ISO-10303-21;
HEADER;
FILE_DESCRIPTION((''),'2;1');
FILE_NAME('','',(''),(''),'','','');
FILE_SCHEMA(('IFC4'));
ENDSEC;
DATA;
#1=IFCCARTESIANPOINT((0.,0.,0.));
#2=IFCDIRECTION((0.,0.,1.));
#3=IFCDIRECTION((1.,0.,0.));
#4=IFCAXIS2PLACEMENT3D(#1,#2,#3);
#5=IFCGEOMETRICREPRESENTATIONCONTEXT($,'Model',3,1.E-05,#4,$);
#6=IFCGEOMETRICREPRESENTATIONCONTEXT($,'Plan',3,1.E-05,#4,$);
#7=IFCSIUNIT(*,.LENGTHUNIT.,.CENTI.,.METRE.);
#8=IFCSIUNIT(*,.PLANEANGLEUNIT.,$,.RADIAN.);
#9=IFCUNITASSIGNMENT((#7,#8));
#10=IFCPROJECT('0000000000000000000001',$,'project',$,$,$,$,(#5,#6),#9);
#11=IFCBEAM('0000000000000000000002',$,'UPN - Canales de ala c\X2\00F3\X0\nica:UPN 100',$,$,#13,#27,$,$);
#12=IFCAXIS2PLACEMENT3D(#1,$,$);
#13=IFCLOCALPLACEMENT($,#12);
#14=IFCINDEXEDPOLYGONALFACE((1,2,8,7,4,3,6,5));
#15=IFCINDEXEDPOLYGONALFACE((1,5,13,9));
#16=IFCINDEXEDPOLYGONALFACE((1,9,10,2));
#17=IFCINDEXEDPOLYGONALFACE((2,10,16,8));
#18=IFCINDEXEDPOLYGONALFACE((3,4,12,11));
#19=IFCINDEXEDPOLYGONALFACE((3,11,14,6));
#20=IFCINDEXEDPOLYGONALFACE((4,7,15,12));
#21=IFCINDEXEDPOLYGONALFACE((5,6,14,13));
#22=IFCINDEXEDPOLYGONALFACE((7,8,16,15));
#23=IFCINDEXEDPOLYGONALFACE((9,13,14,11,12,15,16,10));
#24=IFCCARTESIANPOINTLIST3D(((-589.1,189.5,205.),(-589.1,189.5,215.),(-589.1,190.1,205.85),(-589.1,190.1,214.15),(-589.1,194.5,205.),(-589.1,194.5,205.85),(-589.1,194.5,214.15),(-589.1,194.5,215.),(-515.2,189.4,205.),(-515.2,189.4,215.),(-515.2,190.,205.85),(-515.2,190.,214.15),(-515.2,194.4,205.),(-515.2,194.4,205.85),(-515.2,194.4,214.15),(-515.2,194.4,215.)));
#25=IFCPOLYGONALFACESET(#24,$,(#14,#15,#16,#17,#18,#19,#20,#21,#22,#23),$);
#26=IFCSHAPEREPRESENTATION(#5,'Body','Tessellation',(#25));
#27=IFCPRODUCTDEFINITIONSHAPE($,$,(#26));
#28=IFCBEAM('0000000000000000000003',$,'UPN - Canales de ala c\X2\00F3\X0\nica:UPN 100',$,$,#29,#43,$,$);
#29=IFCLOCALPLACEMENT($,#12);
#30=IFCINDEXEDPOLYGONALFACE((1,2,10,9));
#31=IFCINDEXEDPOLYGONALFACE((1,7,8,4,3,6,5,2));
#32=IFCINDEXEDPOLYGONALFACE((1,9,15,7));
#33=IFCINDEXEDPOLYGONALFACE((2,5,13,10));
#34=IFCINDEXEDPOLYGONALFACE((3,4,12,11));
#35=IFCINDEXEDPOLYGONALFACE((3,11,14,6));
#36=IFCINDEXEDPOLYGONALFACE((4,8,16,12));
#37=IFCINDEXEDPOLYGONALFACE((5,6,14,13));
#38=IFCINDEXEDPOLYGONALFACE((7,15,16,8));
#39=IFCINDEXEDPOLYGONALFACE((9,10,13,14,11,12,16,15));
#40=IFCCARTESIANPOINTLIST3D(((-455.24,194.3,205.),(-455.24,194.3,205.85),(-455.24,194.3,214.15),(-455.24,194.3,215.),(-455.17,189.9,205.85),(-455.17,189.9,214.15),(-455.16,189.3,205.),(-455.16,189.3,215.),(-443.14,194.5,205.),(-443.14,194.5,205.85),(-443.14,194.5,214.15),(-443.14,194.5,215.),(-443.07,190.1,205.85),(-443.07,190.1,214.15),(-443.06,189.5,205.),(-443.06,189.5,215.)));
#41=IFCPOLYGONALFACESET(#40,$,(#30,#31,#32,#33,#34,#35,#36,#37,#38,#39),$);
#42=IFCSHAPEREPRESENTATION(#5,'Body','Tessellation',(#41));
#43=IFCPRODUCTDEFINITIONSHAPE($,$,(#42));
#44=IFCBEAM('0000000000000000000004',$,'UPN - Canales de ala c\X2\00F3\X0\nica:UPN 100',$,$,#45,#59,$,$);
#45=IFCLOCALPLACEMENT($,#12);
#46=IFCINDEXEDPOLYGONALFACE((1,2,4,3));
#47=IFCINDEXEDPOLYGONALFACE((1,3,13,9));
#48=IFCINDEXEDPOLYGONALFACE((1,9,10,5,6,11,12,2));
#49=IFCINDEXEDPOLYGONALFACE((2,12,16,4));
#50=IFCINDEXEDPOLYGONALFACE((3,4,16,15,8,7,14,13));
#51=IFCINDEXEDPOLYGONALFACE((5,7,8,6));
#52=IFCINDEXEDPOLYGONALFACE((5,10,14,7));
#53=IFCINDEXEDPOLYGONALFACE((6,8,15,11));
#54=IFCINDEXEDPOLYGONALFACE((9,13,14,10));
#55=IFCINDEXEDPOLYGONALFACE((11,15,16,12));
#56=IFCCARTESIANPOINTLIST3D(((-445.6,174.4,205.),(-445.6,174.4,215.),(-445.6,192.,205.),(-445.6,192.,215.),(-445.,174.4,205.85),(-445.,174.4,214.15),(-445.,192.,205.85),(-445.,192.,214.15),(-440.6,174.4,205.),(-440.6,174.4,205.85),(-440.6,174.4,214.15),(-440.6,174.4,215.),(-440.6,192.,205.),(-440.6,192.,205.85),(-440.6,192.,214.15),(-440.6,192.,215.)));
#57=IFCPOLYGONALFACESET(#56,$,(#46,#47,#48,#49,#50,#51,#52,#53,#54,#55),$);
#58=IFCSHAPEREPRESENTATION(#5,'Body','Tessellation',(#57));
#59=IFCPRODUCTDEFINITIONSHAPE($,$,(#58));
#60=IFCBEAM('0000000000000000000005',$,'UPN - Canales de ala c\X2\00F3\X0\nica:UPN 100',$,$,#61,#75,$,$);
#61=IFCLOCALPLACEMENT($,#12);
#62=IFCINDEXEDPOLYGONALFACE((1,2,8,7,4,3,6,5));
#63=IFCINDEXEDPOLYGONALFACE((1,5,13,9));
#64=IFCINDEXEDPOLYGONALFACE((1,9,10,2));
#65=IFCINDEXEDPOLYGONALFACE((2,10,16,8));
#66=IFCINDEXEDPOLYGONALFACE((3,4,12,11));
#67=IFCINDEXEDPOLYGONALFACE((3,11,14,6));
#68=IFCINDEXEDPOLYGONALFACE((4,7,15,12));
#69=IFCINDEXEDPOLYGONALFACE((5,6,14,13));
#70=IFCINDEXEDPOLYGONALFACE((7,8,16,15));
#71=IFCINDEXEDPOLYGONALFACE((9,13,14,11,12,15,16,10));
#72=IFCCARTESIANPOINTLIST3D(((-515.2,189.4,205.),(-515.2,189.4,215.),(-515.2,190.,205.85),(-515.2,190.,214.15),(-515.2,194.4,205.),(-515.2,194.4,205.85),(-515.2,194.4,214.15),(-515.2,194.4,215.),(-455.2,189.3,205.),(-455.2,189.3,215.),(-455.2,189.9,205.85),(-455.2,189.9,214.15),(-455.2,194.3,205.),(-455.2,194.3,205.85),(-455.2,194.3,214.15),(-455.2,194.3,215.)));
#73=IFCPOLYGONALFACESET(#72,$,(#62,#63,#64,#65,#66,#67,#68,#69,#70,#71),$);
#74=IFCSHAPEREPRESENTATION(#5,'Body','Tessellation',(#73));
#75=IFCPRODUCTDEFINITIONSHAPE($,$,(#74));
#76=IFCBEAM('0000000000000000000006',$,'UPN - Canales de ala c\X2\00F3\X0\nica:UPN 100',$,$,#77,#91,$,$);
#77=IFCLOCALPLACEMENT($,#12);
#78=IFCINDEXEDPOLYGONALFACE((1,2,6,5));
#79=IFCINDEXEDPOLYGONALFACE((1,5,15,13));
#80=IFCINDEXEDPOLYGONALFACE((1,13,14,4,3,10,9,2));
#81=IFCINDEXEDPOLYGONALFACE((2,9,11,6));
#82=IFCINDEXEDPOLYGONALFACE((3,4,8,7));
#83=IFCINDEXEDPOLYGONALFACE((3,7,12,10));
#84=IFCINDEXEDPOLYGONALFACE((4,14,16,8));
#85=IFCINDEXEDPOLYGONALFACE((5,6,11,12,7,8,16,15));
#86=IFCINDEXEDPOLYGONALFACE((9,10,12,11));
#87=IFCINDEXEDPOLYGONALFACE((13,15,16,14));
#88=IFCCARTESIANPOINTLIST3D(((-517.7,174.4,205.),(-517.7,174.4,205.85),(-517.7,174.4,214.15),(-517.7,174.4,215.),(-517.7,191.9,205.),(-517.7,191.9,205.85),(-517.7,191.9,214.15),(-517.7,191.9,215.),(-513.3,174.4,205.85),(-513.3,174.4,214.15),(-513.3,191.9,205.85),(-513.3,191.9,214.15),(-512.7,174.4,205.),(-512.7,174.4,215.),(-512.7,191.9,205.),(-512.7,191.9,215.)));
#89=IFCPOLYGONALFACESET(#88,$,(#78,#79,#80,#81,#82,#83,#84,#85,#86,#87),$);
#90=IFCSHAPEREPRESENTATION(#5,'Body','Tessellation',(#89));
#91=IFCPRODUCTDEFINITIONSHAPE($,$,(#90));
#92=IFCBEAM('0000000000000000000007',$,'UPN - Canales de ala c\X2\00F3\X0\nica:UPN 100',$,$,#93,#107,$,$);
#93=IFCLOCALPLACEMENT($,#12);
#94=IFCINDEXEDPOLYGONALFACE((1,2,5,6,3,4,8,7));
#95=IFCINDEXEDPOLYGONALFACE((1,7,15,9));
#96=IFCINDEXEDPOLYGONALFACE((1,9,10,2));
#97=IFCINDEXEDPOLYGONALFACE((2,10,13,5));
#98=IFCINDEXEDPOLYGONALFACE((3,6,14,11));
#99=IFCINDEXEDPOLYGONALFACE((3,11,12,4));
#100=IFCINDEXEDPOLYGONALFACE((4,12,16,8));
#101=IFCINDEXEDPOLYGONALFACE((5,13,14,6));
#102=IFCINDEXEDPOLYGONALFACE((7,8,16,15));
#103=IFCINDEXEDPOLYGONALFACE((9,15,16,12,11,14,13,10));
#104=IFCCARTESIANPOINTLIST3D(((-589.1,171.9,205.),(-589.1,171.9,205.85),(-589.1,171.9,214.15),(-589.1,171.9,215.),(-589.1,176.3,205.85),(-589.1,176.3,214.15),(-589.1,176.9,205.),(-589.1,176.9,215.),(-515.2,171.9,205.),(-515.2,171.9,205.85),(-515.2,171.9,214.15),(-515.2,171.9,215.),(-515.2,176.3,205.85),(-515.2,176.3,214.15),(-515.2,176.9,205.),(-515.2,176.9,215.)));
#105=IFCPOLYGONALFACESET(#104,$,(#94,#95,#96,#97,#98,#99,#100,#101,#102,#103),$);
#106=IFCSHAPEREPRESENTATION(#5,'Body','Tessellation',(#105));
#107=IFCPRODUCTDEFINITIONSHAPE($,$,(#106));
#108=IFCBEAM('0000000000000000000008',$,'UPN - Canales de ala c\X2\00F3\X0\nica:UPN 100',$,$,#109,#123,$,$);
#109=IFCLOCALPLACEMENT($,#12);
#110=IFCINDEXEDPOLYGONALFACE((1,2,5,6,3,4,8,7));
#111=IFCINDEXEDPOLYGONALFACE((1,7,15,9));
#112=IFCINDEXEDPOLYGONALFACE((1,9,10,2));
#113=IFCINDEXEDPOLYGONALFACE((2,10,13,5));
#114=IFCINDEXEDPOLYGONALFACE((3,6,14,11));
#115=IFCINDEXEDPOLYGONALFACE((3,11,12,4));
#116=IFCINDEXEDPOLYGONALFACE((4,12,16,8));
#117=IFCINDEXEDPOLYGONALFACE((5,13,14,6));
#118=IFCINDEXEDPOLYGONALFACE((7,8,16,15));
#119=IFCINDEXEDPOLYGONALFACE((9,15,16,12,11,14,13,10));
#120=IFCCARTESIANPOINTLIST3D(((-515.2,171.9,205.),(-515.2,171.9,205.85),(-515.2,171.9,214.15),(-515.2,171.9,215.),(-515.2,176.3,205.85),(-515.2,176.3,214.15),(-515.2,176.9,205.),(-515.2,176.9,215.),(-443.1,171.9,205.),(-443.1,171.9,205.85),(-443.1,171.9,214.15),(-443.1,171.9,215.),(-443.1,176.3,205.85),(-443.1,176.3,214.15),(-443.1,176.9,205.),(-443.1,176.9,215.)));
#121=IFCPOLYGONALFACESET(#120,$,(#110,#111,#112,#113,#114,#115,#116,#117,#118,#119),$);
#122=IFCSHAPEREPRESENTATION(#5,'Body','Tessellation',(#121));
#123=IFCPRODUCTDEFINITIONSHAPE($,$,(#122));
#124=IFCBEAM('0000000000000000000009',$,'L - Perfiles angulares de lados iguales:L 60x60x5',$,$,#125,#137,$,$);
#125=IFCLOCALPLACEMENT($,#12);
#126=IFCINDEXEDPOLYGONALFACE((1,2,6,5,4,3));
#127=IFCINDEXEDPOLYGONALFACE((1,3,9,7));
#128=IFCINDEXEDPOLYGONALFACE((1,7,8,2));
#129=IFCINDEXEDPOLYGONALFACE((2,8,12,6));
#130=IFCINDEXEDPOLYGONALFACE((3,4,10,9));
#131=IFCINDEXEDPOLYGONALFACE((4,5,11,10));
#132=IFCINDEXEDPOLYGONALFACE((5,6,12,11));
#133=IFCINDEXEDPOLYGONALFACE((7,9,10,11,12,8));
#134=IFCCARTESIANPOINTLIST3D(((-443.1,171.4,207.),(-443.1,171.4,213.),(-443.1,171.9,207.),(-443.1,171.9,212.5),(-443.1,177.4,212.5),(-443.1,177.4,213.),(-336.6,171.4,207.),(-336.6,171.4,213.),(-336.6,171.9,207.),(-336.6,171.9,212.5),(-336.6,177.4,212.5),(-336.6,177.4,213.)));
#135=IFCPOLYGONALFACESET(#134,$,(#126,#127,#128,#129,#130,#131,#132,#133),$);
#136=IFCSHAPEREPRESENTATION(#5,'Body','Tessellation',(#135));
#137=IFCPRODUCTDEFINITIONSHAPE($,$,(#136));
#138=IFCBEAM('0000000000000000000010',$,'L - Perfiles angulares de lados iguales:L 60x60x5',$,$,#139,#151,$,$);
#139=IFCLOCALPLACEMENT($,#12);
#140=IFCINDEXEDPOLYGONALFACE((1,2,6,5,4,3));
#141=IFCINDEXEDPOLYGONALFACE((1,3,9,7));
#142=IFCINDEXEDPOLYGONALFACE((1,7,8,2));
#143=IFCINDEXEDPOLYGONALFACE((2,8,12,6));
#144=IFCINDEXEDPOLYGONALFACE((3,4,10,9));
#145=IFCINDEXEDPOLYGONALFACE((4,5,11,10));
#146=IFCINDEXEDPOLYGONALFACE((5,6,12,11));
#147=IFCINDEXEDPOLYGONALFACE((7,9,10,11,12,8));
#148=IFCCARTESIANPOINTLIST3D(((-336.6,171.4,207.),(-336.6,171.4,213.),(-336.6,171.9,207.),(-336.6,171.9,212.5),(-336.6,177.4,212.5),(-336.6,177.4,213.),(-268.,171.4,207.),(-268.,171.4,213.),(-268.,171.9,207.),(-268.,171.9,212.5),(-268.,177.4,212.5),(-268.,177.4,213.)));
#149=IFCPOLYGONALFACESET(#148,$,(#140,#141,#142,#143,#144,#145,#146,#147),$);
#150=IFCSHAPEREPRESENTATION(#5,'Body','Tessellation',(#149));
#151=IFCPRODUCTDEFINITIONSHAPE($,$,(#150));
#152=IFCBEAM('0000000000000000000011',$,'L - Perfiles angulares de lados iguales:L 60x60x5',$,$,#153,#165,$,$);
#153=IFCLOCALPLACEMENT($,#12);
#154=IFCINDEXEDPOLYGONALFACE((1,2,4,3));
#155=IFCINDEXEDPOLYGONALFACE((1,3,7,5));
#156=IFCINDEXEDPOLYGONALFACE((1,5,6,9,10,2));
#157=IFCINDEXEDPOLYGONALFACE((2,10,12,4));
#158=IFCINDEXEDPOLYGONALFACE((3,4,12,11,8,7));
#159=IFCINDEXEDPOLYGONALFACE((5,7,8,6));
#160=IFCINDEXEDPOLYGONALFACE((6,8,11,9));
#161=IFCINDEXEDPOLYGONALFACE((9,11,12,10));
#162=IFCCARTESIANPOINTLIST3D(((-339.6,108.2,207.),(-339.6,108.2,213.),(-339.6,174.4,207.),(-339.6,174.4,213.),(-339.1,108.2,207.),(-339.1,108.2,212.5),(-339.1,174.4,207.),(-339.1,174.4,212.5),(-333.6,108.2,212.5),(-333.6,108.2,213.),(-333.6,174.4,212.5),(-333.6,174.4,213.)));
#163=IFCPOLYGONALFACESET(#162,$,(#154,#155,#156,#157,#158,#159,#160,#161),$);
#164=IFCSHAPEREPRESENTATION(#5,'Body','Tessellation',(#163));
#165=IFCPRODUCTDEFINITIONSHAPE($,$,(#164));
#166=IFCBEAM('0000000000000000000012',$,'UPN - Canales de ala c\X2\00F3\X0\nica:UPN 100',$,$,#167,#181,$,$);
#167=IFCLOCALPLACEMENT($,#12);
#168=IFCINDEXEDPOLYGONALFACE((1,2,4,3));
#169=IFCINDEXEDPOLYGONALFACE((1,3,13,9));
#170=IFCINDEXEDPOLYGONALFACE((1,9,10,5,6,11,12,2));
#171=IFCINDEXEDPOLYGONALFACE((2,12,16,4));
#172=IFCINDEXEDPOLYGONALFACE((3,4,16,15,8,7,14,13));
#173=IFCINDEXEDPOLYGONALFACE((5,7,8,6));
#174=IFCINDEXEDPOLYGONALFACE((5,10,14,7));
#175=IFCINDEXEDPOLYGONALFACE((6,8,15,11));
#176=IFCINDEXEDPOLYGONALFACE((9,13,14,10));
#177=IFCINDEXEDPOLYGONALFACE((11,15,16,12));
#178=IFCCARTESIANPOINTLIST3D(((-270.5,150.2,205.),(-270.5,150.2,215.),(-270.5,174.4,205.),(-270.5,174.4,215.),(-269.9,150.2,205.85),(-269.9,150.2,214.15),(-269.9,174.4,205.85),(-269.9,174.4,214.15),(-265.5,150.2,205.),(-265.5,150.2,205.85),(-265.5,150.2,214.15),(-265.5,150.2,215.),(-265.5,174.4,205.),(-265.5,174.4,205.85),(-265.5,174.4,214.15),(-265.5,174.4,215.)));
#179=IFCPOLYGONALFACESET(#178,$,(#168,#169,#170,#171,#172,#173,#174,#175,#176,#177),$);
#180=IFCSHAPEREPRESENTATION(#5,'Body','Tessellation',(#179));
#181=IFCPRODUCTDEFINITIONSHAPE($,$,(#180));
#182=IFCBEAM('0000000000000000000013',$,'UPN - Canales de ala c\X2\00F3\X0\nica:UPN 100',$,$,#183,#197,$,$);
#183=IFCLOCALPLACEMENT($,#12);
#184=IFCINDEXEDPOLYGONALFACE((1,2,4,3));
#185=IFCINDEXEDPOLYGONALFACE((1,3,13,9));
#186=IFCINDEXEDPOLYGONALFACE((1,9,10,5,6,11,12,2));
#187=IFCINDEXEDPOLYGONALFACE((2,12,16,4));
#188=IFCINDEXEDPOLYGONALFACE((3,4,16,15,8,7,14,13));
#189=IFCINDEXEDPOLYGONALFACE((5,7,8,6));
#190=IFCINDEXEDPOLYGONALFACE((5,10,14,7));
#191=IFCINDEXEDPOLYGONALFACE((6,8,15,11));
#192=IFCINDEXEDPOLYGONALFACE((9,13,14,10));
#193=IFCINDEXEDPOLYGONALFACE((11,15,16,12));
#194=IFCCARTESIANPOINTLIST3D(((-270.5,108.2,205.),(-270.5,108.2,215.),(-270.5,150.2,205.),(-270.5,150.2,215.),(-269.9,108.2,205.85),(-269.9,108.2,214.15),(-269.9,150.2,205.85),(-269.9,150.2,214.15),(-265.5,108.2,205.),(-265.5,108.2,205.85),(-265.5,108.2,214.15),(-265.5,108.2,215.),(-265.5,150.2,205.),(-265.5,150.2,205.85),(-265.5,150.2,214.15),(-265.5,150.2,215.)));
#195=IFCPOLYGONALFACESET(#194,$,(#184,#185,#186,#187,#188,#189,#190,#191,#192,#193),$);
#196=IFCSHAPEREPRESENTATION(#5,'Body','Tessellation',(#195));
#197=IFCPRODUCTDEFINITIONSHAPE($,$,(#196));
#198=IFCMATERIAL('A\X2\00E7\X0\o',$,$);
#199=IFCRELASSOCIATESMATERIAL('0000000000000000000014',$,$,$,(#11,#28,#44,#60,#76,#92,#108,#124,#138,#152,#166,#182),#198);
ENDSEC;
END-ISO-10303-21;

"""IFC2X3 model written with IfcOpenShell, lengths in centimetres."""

from ifc_helpers import new_model, si_unit, frame, frame_2d, origin_with_axes, origin_2d_with_axis, place, context, project, polyline, u_section, outline, extrude, material, element, save


model = new_model("IFC2X3")

# Units and contexts
model_context = context("Model", 3, precision=1e-05, world=origin_with_axes())
plan_context = context("Plan", 3, precision=1e-05, world=origin_with_axes())
ifc_project = project(units=[si_unit("LENGTHUNIT", "METRE", prefix="CENTI"), si_unit("PLANEANGLEUNIT", "RADIAN")], contexts=[model_context, plan_context])

# Shared definitions
ifc_material = material(Name="Aço")

# Beams
beam_1_placement = place(None, frame((-515.2, 191.9, 210.0), z_axis=(-0.999999, 0.001353, 0.0), x_axis=(0.001353, 0.999999, 0.0)))
element("IfcBeam", 1, at=beam_1_placement, material=ifc_material, Name="UPN - Canales de ala cónica:UPN 100", context=model_context, shape_type="SweptSolid", body=[
    extrude(u_section(Depth=10.0, FlangeWidth=5.0, WebThickness=0.6, FlangeThickness=0.85, FilletRadius=0.0, EdgeRadius=0.0, FlangeSlope=0.0, CentreOfGravityInX=0.0, at=frame_2d((0.0, 0.0), x_axis=(1.0, 0.0))), origin_with_axes(), (0.0, 0.0, 1.0), 73.9),
])
beam_2_placement = place(None, frame((-455.2, 191.8, 210.0), z_axis=(0.999863, 0.016526, 0.0), x_axis=(-0.016526, 0.999863, 0.0)))
element("IfcBeam", 2, at=beam_2_placement, material=ifc_material, Name="UPN - Canales de ala cónica:UPN 100", context=model_context, shape_type="SweptSolid", body=[
    extrude(u_section(Depth=10.0, FlangeWidth=5.0, WebThickness=0.6, FlangeThickness=0.85, FilletRadius=0.0, EdgeRadius=0.0, FlangeSlope=0.0, CentreOfGravityInX=0.0, at=frame_2d((0.0, 0.0), x_axis=(1.0, 0.0))), origin_with_axes(), (0.0, 0.0, 1.0), 12.1),
])
beam_3_placement = place(None, frame((-443.1, 174.4, 210.0), z_axis=(0.0, 1.0, 0.0), x_axis=(1.0, 0.0, 0.0)))
element("IfcBeam", 3, at=beam_3_placement, material=ifc_material, Name="UPN - Canales de ala cónica:UPN 100", context=model_context, shape_type="SweptSolid", body=[
    extrude(u_section(Depth=10.0, FlangeWidth=5.0, WebThickness=0.6, FlangeThickness=0.85, FilletRadius=0.0, EdgeRadius=0.0, FlangeSlope=0.0, CentreOfGravityInX=0.0, at=origin_2d_with_axis()), origin_with_axes(), (0.0, 0.0, 1.0), 17.6),
])
beam_4_placement = place(None, frame((-455.2, 191.8, 210.0), z_axis=(-0.999999, 0.001667, 0.0), x_axis=(0.001667, 0.999999, 0.0)))
element("IfcBeam", 4, at=beam_4_placement, material=ifc_material, Name="UPN - Canales de ala cónica:UPN 100", context=model_context, shape_type="SweptSolid", body=[
    extrude(u_section(Depth=10.0, FlangeWidth=5.0, WebThickness=0.6, FlangeThickness=0.85, FilletRadius=0.0, EdgeRadius=0.0, FlangeSlope=0.0, CentreOfGravityInX=0.0, at=frame_2d((0.0, 0.0), x_axis=(1.0, 0.0))), origin_with_axes(), (0.0, 0.0, 1.0), 60.0),
])
beam_5_placement = place(None, frame((-515.2, 174.4, 210.0), z_axis=(0.0, 1.0, 0.0), x_axis=(-1.0, 0.0, 0.0)))
element("IfcBeam", 5, at=beam_5_placement, material=ifc_material, Name="UPN - Canales de ala cónica:UPN 100", context=model_context, shape_type="SweptSolid", body=[
    extrude(u_section(Depth=10.0, FlangeWidth=5.0, WebThickness=0.6, FlangeThickness=0.85, FilletRadius=0.0, EdgeRadius=0.0, FlangeSlope=0.0, CentreOfGravityInX=0.0, at=origin_2d_with_axis()), origin_with_axes(), (0.0, 0.0, 1.0), 17.5),
])
beam_6_placement = place(None, frame((-515.2, 174.4, 210.0), z_axis=(-1.0, 0.0, 0.0), x_axis=(0.0, -1.0, 0.0)))
element("IfcBeam", 6, at=beam_6_placement, material=ifc_material, Name="UPN - Canales de ala cónica:UPN 100", context=model_context, shape_type="SweptSolid", body=[
    extrude(u_section(Depth=10.0, FlangeWidth=5.0, WebThickness=0.6, FlangeThickness=0.85, FilletRadius=0.0, EdgeRadius=0.0, FlangeSlope=0.0, CentreOfGravityInX=0.0, at=origin_2d_with_axis()), origin_with_axes(), (0.0, 0.0, 1.0), 73.9),
])
beam_7_placement = place(None, frame((-443.1, 174.4, 210.0), z_axis=(-1.0, 0.0, 0.0), x_axis=(0.0, -1.0, 0.0)))
element("IfcBeam", 7, at=beam_7_placement, material=ifc_material, Name="UPN - Canales de ala cónica:UPN 100", context=model_context, shape_type="SweptSolid", body=[
    extrude(u_section(Depth=10.0, FlangeWidth=5.0, WebThickness=0.6, FlangeThickness=0.85, FilletRadius=0.0, EdgeRadius=0.0, FlangeSlope=0.0, CentreOfGravityInX=0.0, at=origin_2d_with_axis()), origin_with_axes(), (0.0, 0.0, 1.0), 72.1),
])
beam_8_placement = place(None, frame((-336.6, 174.4, 210.0), z_axis=(-1.0, 0.0, 0.0), x_axis=(0.0, -1.0, 0.0)))
element("IfcBeam", 8, at=beam_8_placement, material=ifc_material, Name="L - Perfiles angulares de lados iguales:L 60x60x5", context=model_context, shape_type="SweptSolid", body=[
    extrude(outline(polyline([(3.0, -3.0), (3.0, 3.0), (-3.0, 3.0), (-3.0, 2.5), (2.5, 2.5), (2.5, -3.0), (3.0, -3.0)])), origin_with_axes(), (0.0, 0.0, 1.0), 106.5),
])
beam_9_placement = place(None, frame((-268.0, 174.4, 210.0), z_axis=(-1.0, 0.0, 0.0), x_axis=(0.0, -1.0, 0.0)))
element("IfcBeam", 9, at=beam_9_placement, material=ifc_material, Name="L - Perfiles angulares de lados iguales:L 60x60x5", context=model_context, shape_type="SweptSolid", body=[
    extrude(outline(polyline([(3.0, -3.0), (3.0, 3.0), (-3.0, 3.0), (-3.0, 2.5), (2.5, 2.5), (2.5, -3.0), (3.0, -3.0)])), origin_with_axes(), (0.0, 0.0, 1.0), 68.6),
])
beam_10_placement = place(None, frame((-336.6, 108.2, 210.0), z_axis=(0.0, 1.0, 0.0), x_axis=(-1.0, 0.0, 0.0)))
element("IfcBeam", 10, at=beam_10_placement, material=ifc_material, Name="L - Perfiles angulares de lados iguales:L 60x60x5", context=model_context, shape_type="SweptSolid", body=[
    extrude(outline(polyline([(3.0, -3.0), (3.0, 3.0), (-3.0, 3.0), (-3.0, 2.5), (2.5, 2.5), (2.5, -3.0), (3.0, -3.0)])), origin_with_axes(), (0.0, 0.0, 1.0), 66.2),
])
beam_11_placement = place(None, frame((-268.0, 150.2, 210.0), z_axis=(0.0, 1.0, 0.0), x_axis=(1.0, 0.0, 0.0)))
element("IfcBeam", 11, at=beam_11_placement, material=ifc_material, Name="UPN - Canales de ala cónica:UPN 100", context=model_context, shape_type="SweptSolid", body=[
    extrude(u_section(Depth=10.0, FlangeWidth=5.0, WebThickness=0.6, FlangeThickness=0.85, FilletRadius=0.0, EdgeRadius=0.0, FlangeSlope=0.0, CentreOfGravityInX=0.0, at=origin_2d_with_axis()), origin_with_axes(), (0.0, 0.0, 1.0), 24.2),
])
beam_12_placement = place(None, frame((-268.0, 108.2, 210.0), z_axis=(0.0, 1.0, 0.0), x_axis=(1.0, 0.0, 0.0)))
element("IfcBeam", 12, at=beam_12_placement, material=ifc_material, Name="UPN - Canales de ala cónica:UPN 100", context=model_context, shape_type="SweptSolid", body=[
    extrude(u_section(Depth=10.0, FlangeWidth=5.0, WebThickness=0.6, FlangeThickness=0.85, FilletRadius=0.0, EdgeRadius=0.0, FlangeSlope=0.0, CentreOfGravityInX=0.0, at=origin_2d_with_axis()), origin_with_axes(), (0.0, 0.0, 1.0), 42.0),
])

save(model, "model.ifc")
